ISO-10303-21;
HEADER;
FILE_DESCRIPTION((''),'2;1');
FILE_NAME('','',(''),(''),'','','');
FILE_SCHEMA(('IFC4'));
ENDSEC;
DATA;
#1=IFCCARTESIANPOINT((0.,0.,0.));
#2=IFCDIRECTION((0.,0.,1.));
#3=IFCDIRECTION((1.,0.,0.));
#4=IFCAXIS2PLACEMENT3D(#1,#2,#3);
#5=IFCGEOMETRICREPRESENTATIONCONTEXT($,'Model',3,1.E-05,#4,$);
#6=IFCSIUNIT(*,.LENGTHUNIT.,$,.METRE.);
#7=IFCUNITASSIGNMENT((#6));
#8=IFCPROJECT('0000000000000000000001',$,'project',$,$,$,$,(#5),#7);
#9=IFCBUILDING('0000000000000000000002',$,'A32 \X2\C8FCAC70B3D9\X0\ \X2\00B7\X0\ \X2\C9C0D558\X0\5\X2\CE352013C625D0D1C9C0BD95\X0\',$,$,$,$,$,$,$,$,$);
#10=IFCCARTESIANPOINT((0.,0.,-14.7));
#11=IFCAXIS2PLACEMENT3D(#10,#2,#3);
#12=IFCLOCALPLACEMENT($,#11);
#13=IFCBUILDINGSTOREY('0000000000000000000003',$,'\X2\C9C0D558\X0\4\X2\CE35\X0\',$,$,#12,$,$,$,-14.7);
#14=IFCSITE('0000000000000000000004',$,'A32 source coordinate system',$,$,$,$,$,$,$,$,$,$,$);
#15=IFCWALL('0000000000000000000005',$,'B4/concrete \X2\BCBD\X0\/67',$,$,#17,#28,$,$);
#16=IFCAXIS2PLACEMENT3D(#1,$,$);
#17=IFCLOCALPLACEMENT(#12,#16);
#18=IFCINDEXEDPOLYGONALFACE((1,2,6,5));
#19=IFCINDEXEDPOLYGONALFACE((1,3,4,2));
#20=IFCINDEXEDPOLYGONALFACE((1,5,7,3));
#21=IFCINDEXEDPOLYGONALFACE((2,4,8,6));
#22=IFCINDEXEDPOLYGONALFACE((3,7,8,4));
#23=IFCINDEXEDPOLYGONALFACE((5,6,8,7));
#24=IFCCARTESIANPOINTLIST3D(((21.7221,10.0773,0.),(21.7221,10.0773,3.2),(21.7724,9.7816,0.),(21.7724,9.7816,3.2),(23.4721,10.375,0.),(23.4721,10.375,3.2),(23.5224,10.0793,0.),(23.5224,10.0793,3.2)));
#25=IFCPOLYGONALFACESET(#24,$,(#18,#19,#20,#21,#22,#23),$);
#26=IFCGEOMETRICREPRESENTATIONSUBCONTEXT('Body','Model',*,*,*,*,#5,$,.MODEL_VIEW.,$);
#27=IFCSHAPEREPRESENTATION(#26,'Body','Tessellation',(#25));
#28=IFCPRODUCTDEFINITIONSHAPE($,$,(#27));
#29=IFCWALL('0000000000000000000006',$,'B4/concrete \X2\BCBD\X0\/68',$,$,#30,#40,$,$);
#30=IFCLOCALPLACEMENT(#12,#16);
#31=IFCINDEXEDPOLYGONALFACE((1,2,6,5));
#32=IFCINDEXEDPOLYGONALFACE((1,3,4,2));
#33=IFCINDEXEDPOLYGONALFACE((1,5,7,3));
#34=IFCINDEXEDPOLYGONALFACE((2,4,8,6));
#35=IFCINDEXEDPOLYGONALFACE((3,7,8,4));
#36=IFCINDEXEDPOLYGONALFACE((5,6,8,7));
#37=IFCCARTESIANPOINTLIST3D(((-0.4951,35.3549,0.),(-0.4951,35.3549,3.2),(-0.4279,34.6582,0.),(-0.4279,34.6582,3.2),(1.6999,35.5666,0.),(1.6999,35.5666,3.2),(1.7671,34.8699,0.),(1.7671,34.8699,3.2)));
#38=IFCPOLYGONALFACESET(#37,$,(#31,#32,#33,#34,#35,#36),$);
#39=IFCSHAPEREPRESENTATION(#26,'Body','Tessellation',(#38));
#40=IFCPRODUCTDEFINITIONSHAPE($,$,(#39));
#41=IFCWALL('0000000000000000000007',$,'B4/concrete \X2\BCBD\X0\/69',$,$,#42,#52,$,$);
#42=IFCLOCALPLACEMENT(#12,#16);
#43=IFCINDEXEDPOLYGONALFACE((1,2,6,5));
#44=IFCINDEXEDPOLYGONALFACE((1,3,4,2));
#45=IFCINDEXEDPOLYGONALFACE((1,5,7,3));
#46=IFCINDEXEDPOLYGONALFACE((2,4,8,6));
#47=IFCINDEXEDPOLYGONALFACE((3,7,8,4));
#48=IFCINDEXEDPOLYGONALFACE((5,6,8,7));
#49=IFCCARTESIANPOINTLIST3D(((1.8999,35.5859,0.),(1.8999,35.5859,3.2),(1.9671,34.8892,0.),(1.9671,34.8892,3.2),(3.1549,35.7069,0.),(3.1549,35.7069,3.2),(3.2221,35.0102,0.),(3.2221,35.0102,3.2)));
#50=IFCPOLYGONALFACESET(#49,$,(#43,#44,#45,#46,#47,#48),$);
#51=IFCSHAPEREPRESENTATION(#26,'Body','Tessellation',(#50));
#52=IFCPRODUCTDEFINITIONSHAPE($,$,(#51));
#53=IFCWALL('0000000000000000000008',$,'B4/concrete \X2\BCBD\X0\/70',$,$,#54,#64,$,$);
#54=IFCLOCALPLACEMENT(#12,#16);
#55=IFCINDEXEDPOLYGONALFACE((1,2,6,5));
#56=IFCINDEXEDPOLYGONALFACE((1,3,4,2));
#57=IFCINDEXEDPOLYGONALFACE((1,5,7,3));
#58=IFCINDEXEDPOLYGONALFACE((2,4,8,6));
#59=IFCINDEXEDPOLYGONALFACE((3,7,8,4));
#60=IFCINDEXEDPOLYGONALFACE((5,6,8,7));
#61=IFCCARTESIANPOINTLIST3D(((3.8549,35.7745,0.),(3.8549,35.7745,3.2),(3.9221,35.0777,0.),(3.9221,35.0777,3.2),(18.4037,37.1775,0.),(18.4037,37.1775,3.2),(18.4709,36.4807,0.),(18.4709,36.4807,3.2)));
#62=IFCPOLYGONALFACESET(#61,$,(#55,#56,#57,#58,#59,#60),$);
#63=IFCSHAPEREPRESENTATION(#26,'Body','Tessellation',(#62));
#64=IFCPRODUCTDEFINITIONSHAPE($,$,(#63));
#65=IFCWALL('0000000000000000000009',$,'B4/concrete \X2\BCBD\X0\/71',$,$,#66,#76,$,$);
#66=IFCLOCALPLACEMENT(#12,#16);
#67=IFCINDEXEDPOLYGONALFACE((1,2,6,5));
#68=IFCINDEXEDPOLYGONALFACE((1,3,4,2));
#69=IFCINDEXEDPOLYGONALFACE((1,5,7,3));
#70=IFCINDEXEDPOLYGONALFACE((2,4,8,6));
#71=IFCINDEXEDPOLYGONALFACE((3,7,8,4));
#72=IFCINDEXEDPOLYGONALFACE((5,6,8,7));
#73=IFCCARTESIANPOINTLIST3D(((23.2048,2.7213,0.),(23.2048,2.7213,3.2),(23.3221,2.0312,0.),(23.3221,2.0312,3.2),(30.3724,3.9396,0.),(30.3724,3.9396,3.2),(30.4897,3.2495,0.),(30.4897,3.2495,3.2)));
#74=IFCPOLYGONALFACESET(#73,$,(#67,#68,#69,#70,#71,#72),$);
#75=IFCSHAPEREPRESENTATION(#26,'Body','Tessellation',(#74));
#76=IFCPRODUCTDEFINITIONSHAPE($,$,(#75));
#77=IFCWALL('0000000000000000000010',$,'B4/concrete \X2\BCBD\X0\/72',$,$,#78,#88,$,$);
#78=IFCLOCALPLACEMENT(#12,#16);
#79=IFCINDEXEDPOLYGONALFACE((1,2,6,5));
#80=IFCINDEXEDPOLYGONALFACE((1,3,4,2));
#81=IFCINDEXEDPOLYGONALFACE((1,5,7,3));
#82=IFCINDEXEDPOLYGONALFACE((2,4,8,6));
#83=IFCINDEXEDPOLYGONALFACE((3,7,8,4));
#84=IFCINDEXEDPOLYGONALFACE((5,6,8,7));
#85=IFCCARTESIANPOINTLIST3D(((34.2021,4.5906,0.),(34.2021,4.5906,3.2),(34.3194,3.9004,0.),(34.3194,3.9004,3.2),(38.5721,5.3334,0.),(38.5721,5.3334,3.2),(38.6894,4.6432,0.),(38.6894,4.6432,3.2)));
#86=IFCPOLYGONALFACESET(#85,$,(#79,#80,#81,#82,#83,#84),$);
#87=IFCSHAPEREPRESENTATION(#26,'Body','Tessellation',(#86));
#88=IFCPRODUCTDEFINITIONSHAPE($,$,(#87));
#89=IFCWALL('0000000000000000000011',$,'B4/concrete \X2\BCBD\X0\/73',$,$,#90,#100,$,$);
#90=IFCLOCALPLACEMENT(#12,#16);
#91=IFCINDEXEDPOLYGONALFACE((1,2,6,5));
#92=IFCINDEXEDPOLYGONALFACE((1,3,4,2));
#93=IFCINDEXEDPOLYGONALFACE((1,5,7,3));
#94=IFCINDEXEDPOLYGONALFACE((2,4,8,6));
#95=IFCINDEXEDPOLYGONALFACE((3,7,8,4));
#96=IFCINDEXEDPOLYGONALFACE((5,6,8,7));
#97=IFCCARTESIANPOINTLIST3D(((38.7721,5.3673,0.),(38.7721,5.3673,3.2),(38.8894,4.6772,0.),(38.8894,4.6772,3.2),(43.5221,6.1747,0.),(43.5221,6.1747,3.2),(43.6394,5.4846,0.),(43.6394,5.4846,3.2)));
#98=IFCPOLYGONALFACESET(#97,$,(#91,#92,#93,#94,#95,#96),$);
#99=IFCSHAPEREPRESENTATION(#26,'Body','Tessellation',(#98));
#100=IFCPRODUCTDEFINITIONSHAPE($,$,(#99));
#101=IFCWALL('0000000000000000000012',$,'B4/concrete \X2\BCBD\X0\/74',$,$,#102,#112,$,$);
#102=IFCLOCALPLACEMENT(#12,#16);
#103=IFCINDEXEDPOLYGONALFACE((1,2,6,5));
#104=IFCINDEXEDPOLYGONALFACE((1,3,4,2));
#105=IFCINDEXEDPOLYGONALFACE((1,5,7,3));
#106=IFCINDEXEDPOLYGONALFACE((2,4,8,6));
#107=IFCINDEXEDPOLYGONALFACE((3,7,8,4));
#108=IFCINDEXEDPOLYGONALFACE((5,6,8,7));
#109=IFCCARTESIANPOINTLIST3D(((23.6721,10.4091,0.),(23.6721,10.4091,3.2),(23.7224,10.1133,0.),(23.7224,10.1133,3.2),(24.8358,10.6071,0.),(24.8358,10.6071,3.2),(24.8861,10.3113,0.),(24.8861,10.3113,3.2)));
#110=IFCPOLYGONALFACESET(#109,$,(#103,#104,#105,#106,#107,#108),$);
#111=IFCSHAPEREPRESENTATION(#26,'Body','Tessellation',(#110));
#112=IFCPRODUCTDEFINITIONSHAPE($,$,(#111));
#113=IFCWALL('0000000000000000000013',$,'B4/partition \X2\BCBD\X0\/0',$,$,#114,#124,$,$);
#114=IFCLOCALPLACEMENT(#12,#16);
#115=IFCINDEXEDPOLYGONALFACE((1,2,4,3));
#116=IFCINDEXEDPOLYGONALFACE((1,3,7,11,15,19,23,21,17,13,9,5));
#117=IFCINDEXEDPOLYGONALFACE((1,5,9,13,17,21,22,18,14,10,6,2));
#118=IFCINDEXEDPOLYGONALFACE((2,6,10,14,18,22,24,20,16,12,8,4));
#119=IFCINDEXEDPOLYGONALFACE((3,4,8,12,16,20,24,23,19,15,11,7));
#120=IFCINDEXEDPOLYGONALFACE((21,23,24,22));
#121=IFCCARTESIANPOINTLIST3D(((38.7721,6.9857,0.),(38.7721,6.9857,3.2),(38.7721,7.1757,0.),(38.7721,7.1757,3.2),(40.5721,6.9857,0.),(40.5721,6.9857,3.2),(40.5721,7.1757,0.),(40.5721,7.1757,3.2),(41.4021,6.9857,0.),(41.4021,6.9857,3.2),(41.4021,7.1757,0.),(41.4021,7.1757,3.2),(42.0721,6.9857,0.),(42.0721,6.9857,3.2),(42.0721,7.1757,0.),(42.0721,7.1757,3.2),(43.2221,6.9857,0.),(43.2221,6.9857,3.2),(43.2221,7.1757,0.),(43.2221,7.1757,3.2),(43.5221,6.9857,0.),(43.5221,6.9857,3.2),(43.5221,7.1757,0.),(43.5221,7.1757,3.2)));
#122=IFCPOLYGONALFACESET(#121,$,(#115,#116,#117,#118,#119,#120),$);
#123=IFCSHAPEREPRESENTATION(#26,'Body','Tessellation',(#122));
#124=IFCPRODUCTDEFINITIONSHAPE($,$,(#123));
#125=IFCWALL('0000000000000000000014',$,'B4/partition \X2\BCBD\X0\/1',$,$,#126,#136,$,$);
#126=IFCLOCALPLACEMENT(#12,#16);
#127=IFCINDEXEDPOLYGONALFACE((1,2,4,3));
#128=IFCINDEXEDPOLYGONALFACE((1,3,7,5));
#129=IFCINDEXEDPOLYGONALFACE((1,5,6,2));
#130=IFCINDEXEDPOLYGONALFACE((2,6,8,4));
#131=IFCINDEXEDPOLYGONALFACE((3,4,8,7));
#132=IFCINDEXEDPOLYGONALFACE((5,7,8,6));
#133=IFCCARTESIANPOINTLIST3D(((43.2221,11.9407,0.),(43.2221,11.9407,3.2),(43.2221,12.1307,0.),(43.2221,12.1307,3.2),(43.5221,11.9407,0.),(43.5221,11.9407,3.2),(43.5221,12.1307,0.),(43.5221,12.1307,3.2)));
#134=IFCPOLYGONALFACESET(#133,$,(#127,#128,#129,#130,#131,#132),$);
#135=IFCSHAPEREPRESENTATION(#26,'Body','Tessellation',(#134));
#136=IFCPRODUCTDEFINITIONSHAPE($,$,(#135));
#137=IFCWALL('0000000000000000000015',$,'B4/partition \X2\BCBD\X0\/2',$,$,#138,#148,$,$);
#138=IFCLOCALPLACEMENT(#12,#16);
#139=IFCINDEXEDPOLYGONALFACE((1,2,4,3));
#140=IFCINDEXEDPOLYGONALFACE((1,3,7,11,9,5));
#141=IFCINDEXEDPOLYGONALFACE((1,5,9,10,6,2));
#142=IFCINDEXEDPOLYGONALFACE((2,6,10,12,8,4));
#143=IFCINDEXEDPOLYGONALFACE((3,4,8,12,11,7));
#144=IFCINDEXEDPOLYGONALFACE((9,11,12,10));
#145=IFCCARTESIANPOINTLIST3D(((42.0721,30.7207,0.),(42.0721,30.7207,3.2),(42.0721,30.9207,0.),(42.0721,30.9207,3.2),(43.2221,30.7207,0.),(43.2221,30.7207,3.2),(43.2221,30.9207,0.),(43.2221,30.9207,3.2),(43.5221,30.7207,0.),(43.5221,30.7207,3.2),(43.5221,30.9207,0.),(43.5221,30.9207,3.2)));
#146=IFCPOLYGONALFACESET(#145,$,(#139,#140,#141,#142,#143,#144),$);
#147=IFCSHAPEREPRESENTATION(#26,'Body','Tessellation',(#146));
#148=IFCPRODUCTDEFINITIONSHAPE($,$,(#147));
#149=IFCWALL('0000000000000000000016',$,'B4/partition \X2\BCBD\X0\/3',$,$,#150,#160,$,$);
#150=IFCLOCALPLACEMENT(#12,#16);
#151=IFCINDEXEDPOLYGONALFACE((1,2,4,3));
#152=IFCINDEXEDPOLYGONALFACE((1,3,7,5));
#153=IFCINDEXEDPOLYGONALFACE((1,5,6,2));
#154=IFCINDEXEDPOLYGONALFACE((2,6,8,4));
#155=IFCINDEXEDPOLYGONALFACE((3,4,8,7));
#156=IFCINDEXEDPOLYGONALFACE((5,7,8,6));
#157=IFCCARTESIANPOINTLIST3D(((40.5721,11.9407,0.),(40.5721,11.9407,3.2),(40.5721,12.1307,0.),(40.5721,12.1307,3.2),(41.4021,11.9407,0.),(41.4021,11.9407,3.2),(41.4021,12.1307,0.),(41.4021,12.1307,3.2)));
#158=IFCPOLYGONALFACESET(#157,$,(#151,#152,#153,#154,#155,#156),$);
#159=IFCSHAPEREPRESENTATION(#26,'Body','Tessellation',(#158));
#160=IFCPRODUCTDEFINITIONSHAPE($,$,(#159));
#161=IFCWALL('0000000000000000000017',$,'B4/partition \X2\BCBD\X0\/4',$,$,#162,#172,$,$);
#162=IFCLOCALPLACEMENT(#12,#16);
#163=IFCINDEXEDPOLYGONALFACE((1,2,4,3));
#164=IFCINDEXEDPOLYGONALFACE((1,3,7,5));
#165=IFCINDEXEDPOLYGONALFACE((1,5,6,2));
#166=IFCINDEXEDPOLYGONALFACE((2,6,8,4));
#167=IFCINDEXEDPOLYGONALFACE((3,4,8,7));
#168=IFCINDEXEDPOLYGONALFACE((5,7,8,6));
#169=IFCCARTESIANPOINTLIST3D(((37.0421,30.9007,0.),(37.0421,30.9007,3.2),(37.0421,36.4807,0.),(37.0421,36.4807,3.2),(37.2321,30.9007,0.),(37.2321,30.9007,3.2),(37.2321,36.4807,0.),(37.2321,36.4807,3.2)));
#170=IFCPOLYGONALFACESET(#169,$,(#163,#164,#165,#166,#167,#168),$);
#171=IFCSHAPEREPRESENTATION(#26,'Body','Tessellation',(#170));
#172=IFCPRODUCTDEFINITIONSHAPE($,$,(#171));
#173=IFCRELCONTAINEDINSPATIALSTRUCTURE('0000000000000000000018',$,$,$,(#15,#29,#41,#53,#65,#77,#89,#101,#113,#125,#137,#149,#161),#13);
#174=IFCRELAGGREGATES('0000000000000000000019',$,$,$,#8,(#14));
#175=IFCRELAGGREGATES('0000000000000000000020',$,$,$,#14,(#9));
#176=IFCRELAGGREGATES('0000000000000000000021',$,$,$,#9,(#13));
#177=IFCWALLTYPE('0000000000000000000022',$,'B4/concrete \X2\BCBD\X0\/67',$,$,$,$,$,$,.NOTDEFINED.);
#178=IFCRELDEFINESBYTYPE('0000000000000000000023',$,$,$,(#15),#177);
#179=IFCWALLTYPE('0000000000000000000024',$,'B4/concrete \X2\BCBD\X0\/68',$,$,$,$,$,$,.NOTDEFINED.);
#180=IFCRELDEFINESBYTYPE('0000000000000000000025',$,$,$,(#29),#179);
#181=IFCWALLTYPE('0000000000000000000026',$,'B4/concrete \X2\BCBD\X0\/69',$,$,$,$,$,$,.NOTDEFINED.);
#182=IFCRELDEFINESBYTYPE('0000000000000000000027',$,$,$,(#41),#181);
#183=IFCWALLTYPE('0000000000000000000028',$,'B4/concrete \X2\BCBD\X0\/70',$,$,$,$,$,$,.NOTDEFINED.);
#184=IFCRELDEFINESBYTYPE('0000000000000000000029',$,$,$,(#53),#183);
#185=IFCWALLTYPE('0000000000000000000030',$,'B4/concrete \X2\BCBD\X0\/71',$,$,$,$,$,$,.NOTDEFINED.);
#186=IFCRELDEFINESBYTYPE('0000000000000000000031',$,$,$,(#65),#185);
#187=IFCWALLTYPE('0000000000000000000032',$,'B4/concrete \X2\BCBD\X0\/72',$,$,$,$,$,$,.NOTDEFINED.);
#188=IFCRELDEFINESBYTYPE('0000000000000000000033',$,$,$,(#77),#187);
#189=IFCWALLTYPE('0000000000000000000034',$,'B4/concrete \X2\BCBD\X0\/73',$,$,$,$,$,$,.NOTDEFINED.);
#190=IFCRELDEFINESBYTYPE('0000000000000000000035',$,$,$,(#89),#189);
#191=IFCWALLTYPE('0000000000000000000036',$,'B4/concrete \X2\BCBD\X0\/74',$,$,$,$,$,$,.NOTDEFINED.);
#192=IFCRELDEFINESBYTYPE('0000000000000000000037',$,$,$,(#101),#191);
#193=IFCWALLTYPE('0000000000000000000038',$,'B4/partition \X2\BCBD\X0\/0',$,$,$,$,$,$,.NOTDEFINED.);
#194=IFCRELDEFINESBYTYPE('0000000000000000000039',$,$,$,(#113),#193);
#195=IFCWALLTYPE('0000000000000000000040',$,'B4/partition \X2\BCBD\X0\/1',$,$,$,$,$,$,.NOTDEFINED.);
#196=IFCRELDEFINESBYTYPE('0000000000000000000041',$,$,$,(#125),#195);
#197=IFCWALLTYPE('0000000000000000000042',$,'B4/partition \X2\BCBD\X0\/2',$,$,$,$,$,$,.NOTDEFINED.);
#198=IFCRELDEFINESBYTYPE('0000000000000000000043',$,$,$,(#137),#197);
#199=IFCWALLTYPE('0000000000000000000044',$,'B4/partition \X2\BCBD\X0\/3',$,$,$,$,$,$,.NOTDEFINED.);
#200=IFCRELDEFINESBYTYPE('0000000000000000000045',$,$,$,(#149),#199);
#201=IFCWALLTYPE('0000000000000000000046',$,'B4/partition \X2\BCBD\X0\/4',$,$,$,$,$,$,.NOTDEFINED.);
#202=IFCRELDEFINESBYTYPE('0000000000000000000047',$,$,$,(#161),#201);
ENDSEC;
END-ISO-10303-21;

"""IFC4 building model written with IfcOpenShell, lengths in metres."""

from ifc_helpers import new_model, si_unit, frame, origin, origin_with_axes, place, context, subcontext, project, spatial, polyline, outline, extrude, source, transform, mapped, type_object, type_shapes, element, save


model = new_model("IFC4")

# Units and contexts
model_context = context("Model", 3, precision=1e-05, world=origin_with_axes())
body_context = subcontext(model_context, "Body", "Model", "MODEL_VIEW")
ifc_project = project(units=[si_unit("LENGTHUNIT", "METRE")], contexts=[model_context])

# Site, building, storey
site = spatial("IfcSite", under=ifc_project, Name="A32 source coordinate system")
building = spatial("IfcBuilding", under=site, Name="A32 주거동 · 지하5층–옥탑지붕")
storey_placement = place(None, frame((0.0, 0.0, -14.7), z_axis=(0.0, 0.0, 1.0), x_axis=(1.0, 0.0, 0.0)))
storey = spatial("IfcBuildingStorey", under=building, at=storey_placement, Name="지하4층", Elevation=-14.7)

# Walls
wall_type_1 = type_object("IfcWallType", Name="B4/concrete 벽/67", PredefinedType="NOTDEFINED")
shared_shape_1 = source(origin(), body_context, "Body", "SweptSolid", [
    extrude(outline(polyline([(21.7221, 10.0773), (23.4721, 10.375), (23.5224, 10.0793), (21.7724, 9.7816), (21.7221, 10.0773)])), origin(), (0.0, 0.0, 1.0), 3.2),
])
type_shapes(wall_type_1, [shared_shape_1])
wall_1_placement = place(storey_placement, origin_with_axes())
element("IfcWall", 1, at=wall_1_placement, inside=storey, type_object=wall_type_1, Name="B4/concrete 벽/67", context=body_context, shape_type="MappedRepresentation", body=[
    mapped(shared_shape_1, transform((0.0, 0.0, 0.0), scale=1.0)),
])
wall_type_2 = type_object("IfcWallType", Name="B4/concrete 벽/68", PredefinedType="NOTDEFINED")
shared_shape_2 = source(origin(), body_context, "Body", "SweptSolid", [
    extrude(outline(polyline([(-0.4279, 34.6582), (-0.4951, 35.3549), (1.6999, 35.5666), (1.7671, 34.8699), (-0.4279, 34.6582)])), origin(), (0.0, 0.0, 1.0), 3.2),
])
type_shapes(wall_type_2, [shared_shape_2])
wall_2_placement = place(storey_placement, origin_with_axes())
element("IfcWall", 2, at=wall_2_placement, inside=storey, type_object=wall_type_2, Name="B4/concrete 벽/68", context=body_context, shape_type="MappedRepresentation", body=[
    mapped(shared_shape_2, transform((0.0, 0.0, 0.0), scale=1.0)),
])
wall_type_3 = type_object("IfcWallType", Name="B4/concrete 벽/69", PredefinedType="NOTDEFINED")
shared_shape_3 = source(origin(), body_context, "Body", "SweptSolid", [
    extrude(outline(polyline([(1.9671, 34.8892), (1.8999, 35.5859), (3.1549, 35.7069), (3.2221, 35.0102), (1.9671, 34.8892)])), origin(), (0.0, 0.0, 1.0), 3.2),
])
type_shapes(wall_type_3, [shared_shape_3])
wall_3_placement = place(storey_placement, origin_with_axes())
element("IfcWall", 3, at=wall_3_placement, inside=storey, type_object=wall_type_3, Name="B4/concrete 벽/69", context=body_context, shape_type="MappedRepresentation", body=[
    mapped(shared_shape_3, transform((0.0, 0.0, 0.0), scale=1.0)),
])
wall_type_4 = type_object("IfcWallType", Name="B4/concrete 벽/70", PredefinedType="NOTDEFINED")
shared_shape_4 = source(origin(), body_context, "Body", "SweptSolid", [
    extrude(outline(polyline([(3.9221, 35.0777), (3.8549, 35.7745), (18.4037, 37.1775), (18.4709, 36.4807), (3.9221, 35.0777)])), origin(), (0.0, 0.0, 1.0), 3.2),
])
type_shapes(wall_type_4, [shared_shape_4])
wall_4_placement = place(storey_placement, origin_with_axes())
element("IfcWall", 4, at=wall_4_placement, inside=storey, type_object=wall_type_4, Name="B4/concrete 벽/70", context=body_context, shape_type="MappedRepresentation", body=[
    mapped(shared_shape_4, transform((0.0, 0.0, 0.0), scale=1.0)),
])
wall_type_5 = type_object("IfcWallType", Name="B4/concrete 벽/71", PredefinedType="NOTDEFINED")
shared_shape_5 = source(origin(), body_context, "Body", "SweptSolid", [
    extrude(outline(polyline([(30.4897, 3.2495), (23.3221, 2.0312), (23.2048, 2.7213), (30.3724, 3.9396), (30.4897, 3.2495)])), origin(), (0.0, 0.0, 1.0), 3.2),
])
type_shapes(wall_type_5, [shared_shape_5])
wall_5_placement = place(storey_placement, origin_with_axes())
element("IfcWall", 5, at=wall_5_placement, inside=storey, type_object=wall_type_5, Name="B4/concrete 벽/71", context=body_context, shape_type="MappedRepresentation", body=[
    mapped(shared_shape_5, transform((0.0, 0.0, 0.0), scale=1.0)),
])
wall_type_6 = type_object("IfcWallType", Name="B4/concrete 벽/72", PredefinedType="NOTDEFINED")
shared_shape_6 = source(origin(), body_context, "Body", "SweptSolid", [
    extrude(outline(polyline([(38.5721, 5.3334), (38.6894, 4.6432), (34.3194, 3.9004), (34.2021, 4.5906), (38.5721, 5.3334)])), origin(), (0.0, 0.0, 1.0), 3.2),
])
type_shapes(wall_type_6, [shared_shape_6])
wall_6_placement = place(storey_placement, origin_with_axes())
element("IfcWall", 6, at=wall_6_placement, inside=storey, type_object=wall_type_6, Name="B4/concrete 벽/72", context=body_context, shape_type="MappedRepresentation", body=[
    mapped(shared_shape_6, transform((0.0, 0.0, 0.0), scale=1.0)),
])
wall_type_7 = type_object("IfcWallType", Name="B4/concrete 벽/73", PredefinedType="NOTDEFINED")
shared_shape_7 = source(origin(), body_context, "Body", "SweptSolid", [
    extrude(outline(polyline([(38.7721, 5.3673), (43.5221, 6.1747), (43.6394, 5.4846), (38.8894, 4.6772), (38.7721, 5.3673)])), origin(), (0.0, 0.0, 1.0), 3.2),
])
type_shapes(wall_type_7, [shared_shape_7])
wall_7_placement = place(storey_placement, origin_with_axes())
element("IfcWall", 7, at=wall_7_placement, inside=storey, type_object=wall_type_7, Name="B4/concrete 벽/73", context=body_context, shape_type="MappedRepresentation", body=[
    mapped(shared_shape_7, transform((0.0, 0.0, 0.0), scale=1.0)),
])
wall_type_8 = type_object("IfcWallType", Name="B4/concrete 벽/74", PredefinedType="NOTDEFINED")
shared_shape_8 = source(origin(), body_context, "Body", "SweptSolid", [
    extrude(outline(polyline([(24.8358, 10.6071), (24.8861, 10.3113), (23.7224, 10.1133), (23.6721, 10.4091), (24.8358, 10.6071)])), origin(), (0.0, 0.0, 1.0), 3.2),
])
type_shapes(wall_type_8, [shared_shape_8])
wall_8_placement = place(storey_placement, origin_with_axes())
element("IfcWall", 8, at=wall_8_placement, inside=storey, type_object=wall_type_8, Name="B4/concrete 벽/74", context=body_context, shape_type="MappedRepresentation", body=[
    mapped(shared_shape_8, transform((0.0, 0.0, 0.0), scale=1.0)),
])
wall_type_9 = type_object("IfcWallType", Name="B4/partition 벽/0", PredefinedType="NOTDEFINED")
shared_shape_9 = source(origin(), body_context, "Body", "SweptSolid", [
    extrude(outline(polyline([(43.5221, 7.1757), (43.5221, 6.9857), (43.2221, 6.9857), (42.0721, 6.9857), (41.4021, 6.9857), (40.5721, 6.9857), (38.7721, 6.9857), (38.7721, 7.1757), (40.5721, 7.1757), (41.4021, 7.1757), (42.0721, 7.1757), (43.2221, 7.1757), (43.5221, 7.1757)])), origin(), (0.0, 0.0, 1.0), 3.2),
])
type_shapes(wall_type_9, [shared_shape_9])
wall_9_placement = place(storey_placement, origin_with_axes())
element("IfcWall", 9, at=wall_9_placement, inside=storey, type_object=wall_type_9, Name="B4/partition 벽/0", context=body_context, shape_type="MappedRepresentation", body=[
    mapped(shared_shape_9, transform((0.0, 0.0, 0.0), scale=1.0)),
])
wall_type_10 = type_object("IfcWallType", Name="B4/partition 벽/1", PredefinedType="NOTDEFINED")
shared_shape_10 = source(origin(), body_context, "Body", "SweptSolid", [
    extrude(outline(polyline([(43.2221, 12.1307), (43.5221, 12.1307), (43.5221, 11.9407), (43.2221, 11.9407), (43.2221, 12.1307)])), origin(), (0.0, 0.0, 1.0), 3.2),
])
type_shapes(wall_type_10, [shared_shape_10])
wall_10_placement = place(storey_placement, origin_with_axes())
element("IfcWall", 10, at=wall_10_placement, inside=storey, type_object=wall_type_10, Name="B4/partition 벽/1", context=body_context, shape_type="MappedRepresentation", body=[
    mapped(shared_shape_10, transform((0.0, 0.0, 0.0), scale=1.0)),
])
wall_type_11 = type_object("IfcWallType", Name="B4/partition 벽/2", PredefinedType="NOTDEFINED")
shared_shape_11 = source(origin(), body_context, "Body", "SweptSolid", [
    extrude(outline(polyline([(42.0721, 30.7207), (42.0721, 30.9207), (43.2221, 30.9207), (43.5221, 30.9207), (43.5221, 30.7207), (43.2221, 30.7207), (42.0721, 30.7207)])), origin(), (0.0, 0.0, 1.0), 3.2),
])
type_shapes(wall_type_11, [shared_shape_11])
wall_11_placement = place(storey_placement, origin_with_axes())
element("IfcWall", 11, at=wall_11_placement, inside=storey, type_object=wall_type_11, Name="B4/partition 벽/2", context=body_context, shape_type="MappedRepresentation", body=[
    mapped(shared_shape_11, transform((0.0, 0.0, 0.0), scale=1.0)),
])
wall_type_12 = type_object("IfcWallType", Name="B4/partition 벽/3", PredefinedType="NOTDEFINED")
shared_shape_12 = source(origin(), body_context, "Body", "SweptSolid", [
    extrude(outline(polyline([(41.4021, 12.1307), (41.4021, 11.9407), (40.5721, 11.9407), (40.5721, 12.1307), (41.4021, 12.1307)])), origin(), (0.0, 0.0, 1.0), 3.2),
])
type_shapes(wall_type_12, [shared_shape_12])
wall_12_placement = place(storey_placement, origin_with_axes())
element("IfcWall", 12, at=wall_12_placement, inside=storey, type_object=wall_type_12, Name="B4/partition 벽/3", context=body_context, shape_type="MappedRepresentation", body=[
    mapped(shared_shape_12, transform((0.0, 0.0, 0.0), scale=1.0)),
])
wall_type_13 = type_object("IfcWallType", Name="B4/partition 벽/4", PredefinedType="NOTDEFINED")
shared_shape_13 = source(origin(), body_context, "Body", "SweptSolid", [
    extrude(outline(polyline([(37.2321, 36.4807), (37.2321, 30.9007), (37.0421, 30.9007), (37.0421, 36.4807), (37.2321, 36.4807)])), origin(), (0.0, 0.0, 1.0), 3.2),
])
type_shapes(wall_type_13, [shared_shape_13])
wall_13_placement = place(storey_placement, origin_with_axes())
element("IfcWall", 13, at=wall_13_placement, inside=storey, type_object=wall_type_13, Name="B4/partition 벽/4", context=body_context, shape_type="MappedRepresentation", body=[
    mapped(shared_shape_13, transform((0.0, 0.0, 0.0), scale=1.0)),
])

save(model, "model.ifc")
